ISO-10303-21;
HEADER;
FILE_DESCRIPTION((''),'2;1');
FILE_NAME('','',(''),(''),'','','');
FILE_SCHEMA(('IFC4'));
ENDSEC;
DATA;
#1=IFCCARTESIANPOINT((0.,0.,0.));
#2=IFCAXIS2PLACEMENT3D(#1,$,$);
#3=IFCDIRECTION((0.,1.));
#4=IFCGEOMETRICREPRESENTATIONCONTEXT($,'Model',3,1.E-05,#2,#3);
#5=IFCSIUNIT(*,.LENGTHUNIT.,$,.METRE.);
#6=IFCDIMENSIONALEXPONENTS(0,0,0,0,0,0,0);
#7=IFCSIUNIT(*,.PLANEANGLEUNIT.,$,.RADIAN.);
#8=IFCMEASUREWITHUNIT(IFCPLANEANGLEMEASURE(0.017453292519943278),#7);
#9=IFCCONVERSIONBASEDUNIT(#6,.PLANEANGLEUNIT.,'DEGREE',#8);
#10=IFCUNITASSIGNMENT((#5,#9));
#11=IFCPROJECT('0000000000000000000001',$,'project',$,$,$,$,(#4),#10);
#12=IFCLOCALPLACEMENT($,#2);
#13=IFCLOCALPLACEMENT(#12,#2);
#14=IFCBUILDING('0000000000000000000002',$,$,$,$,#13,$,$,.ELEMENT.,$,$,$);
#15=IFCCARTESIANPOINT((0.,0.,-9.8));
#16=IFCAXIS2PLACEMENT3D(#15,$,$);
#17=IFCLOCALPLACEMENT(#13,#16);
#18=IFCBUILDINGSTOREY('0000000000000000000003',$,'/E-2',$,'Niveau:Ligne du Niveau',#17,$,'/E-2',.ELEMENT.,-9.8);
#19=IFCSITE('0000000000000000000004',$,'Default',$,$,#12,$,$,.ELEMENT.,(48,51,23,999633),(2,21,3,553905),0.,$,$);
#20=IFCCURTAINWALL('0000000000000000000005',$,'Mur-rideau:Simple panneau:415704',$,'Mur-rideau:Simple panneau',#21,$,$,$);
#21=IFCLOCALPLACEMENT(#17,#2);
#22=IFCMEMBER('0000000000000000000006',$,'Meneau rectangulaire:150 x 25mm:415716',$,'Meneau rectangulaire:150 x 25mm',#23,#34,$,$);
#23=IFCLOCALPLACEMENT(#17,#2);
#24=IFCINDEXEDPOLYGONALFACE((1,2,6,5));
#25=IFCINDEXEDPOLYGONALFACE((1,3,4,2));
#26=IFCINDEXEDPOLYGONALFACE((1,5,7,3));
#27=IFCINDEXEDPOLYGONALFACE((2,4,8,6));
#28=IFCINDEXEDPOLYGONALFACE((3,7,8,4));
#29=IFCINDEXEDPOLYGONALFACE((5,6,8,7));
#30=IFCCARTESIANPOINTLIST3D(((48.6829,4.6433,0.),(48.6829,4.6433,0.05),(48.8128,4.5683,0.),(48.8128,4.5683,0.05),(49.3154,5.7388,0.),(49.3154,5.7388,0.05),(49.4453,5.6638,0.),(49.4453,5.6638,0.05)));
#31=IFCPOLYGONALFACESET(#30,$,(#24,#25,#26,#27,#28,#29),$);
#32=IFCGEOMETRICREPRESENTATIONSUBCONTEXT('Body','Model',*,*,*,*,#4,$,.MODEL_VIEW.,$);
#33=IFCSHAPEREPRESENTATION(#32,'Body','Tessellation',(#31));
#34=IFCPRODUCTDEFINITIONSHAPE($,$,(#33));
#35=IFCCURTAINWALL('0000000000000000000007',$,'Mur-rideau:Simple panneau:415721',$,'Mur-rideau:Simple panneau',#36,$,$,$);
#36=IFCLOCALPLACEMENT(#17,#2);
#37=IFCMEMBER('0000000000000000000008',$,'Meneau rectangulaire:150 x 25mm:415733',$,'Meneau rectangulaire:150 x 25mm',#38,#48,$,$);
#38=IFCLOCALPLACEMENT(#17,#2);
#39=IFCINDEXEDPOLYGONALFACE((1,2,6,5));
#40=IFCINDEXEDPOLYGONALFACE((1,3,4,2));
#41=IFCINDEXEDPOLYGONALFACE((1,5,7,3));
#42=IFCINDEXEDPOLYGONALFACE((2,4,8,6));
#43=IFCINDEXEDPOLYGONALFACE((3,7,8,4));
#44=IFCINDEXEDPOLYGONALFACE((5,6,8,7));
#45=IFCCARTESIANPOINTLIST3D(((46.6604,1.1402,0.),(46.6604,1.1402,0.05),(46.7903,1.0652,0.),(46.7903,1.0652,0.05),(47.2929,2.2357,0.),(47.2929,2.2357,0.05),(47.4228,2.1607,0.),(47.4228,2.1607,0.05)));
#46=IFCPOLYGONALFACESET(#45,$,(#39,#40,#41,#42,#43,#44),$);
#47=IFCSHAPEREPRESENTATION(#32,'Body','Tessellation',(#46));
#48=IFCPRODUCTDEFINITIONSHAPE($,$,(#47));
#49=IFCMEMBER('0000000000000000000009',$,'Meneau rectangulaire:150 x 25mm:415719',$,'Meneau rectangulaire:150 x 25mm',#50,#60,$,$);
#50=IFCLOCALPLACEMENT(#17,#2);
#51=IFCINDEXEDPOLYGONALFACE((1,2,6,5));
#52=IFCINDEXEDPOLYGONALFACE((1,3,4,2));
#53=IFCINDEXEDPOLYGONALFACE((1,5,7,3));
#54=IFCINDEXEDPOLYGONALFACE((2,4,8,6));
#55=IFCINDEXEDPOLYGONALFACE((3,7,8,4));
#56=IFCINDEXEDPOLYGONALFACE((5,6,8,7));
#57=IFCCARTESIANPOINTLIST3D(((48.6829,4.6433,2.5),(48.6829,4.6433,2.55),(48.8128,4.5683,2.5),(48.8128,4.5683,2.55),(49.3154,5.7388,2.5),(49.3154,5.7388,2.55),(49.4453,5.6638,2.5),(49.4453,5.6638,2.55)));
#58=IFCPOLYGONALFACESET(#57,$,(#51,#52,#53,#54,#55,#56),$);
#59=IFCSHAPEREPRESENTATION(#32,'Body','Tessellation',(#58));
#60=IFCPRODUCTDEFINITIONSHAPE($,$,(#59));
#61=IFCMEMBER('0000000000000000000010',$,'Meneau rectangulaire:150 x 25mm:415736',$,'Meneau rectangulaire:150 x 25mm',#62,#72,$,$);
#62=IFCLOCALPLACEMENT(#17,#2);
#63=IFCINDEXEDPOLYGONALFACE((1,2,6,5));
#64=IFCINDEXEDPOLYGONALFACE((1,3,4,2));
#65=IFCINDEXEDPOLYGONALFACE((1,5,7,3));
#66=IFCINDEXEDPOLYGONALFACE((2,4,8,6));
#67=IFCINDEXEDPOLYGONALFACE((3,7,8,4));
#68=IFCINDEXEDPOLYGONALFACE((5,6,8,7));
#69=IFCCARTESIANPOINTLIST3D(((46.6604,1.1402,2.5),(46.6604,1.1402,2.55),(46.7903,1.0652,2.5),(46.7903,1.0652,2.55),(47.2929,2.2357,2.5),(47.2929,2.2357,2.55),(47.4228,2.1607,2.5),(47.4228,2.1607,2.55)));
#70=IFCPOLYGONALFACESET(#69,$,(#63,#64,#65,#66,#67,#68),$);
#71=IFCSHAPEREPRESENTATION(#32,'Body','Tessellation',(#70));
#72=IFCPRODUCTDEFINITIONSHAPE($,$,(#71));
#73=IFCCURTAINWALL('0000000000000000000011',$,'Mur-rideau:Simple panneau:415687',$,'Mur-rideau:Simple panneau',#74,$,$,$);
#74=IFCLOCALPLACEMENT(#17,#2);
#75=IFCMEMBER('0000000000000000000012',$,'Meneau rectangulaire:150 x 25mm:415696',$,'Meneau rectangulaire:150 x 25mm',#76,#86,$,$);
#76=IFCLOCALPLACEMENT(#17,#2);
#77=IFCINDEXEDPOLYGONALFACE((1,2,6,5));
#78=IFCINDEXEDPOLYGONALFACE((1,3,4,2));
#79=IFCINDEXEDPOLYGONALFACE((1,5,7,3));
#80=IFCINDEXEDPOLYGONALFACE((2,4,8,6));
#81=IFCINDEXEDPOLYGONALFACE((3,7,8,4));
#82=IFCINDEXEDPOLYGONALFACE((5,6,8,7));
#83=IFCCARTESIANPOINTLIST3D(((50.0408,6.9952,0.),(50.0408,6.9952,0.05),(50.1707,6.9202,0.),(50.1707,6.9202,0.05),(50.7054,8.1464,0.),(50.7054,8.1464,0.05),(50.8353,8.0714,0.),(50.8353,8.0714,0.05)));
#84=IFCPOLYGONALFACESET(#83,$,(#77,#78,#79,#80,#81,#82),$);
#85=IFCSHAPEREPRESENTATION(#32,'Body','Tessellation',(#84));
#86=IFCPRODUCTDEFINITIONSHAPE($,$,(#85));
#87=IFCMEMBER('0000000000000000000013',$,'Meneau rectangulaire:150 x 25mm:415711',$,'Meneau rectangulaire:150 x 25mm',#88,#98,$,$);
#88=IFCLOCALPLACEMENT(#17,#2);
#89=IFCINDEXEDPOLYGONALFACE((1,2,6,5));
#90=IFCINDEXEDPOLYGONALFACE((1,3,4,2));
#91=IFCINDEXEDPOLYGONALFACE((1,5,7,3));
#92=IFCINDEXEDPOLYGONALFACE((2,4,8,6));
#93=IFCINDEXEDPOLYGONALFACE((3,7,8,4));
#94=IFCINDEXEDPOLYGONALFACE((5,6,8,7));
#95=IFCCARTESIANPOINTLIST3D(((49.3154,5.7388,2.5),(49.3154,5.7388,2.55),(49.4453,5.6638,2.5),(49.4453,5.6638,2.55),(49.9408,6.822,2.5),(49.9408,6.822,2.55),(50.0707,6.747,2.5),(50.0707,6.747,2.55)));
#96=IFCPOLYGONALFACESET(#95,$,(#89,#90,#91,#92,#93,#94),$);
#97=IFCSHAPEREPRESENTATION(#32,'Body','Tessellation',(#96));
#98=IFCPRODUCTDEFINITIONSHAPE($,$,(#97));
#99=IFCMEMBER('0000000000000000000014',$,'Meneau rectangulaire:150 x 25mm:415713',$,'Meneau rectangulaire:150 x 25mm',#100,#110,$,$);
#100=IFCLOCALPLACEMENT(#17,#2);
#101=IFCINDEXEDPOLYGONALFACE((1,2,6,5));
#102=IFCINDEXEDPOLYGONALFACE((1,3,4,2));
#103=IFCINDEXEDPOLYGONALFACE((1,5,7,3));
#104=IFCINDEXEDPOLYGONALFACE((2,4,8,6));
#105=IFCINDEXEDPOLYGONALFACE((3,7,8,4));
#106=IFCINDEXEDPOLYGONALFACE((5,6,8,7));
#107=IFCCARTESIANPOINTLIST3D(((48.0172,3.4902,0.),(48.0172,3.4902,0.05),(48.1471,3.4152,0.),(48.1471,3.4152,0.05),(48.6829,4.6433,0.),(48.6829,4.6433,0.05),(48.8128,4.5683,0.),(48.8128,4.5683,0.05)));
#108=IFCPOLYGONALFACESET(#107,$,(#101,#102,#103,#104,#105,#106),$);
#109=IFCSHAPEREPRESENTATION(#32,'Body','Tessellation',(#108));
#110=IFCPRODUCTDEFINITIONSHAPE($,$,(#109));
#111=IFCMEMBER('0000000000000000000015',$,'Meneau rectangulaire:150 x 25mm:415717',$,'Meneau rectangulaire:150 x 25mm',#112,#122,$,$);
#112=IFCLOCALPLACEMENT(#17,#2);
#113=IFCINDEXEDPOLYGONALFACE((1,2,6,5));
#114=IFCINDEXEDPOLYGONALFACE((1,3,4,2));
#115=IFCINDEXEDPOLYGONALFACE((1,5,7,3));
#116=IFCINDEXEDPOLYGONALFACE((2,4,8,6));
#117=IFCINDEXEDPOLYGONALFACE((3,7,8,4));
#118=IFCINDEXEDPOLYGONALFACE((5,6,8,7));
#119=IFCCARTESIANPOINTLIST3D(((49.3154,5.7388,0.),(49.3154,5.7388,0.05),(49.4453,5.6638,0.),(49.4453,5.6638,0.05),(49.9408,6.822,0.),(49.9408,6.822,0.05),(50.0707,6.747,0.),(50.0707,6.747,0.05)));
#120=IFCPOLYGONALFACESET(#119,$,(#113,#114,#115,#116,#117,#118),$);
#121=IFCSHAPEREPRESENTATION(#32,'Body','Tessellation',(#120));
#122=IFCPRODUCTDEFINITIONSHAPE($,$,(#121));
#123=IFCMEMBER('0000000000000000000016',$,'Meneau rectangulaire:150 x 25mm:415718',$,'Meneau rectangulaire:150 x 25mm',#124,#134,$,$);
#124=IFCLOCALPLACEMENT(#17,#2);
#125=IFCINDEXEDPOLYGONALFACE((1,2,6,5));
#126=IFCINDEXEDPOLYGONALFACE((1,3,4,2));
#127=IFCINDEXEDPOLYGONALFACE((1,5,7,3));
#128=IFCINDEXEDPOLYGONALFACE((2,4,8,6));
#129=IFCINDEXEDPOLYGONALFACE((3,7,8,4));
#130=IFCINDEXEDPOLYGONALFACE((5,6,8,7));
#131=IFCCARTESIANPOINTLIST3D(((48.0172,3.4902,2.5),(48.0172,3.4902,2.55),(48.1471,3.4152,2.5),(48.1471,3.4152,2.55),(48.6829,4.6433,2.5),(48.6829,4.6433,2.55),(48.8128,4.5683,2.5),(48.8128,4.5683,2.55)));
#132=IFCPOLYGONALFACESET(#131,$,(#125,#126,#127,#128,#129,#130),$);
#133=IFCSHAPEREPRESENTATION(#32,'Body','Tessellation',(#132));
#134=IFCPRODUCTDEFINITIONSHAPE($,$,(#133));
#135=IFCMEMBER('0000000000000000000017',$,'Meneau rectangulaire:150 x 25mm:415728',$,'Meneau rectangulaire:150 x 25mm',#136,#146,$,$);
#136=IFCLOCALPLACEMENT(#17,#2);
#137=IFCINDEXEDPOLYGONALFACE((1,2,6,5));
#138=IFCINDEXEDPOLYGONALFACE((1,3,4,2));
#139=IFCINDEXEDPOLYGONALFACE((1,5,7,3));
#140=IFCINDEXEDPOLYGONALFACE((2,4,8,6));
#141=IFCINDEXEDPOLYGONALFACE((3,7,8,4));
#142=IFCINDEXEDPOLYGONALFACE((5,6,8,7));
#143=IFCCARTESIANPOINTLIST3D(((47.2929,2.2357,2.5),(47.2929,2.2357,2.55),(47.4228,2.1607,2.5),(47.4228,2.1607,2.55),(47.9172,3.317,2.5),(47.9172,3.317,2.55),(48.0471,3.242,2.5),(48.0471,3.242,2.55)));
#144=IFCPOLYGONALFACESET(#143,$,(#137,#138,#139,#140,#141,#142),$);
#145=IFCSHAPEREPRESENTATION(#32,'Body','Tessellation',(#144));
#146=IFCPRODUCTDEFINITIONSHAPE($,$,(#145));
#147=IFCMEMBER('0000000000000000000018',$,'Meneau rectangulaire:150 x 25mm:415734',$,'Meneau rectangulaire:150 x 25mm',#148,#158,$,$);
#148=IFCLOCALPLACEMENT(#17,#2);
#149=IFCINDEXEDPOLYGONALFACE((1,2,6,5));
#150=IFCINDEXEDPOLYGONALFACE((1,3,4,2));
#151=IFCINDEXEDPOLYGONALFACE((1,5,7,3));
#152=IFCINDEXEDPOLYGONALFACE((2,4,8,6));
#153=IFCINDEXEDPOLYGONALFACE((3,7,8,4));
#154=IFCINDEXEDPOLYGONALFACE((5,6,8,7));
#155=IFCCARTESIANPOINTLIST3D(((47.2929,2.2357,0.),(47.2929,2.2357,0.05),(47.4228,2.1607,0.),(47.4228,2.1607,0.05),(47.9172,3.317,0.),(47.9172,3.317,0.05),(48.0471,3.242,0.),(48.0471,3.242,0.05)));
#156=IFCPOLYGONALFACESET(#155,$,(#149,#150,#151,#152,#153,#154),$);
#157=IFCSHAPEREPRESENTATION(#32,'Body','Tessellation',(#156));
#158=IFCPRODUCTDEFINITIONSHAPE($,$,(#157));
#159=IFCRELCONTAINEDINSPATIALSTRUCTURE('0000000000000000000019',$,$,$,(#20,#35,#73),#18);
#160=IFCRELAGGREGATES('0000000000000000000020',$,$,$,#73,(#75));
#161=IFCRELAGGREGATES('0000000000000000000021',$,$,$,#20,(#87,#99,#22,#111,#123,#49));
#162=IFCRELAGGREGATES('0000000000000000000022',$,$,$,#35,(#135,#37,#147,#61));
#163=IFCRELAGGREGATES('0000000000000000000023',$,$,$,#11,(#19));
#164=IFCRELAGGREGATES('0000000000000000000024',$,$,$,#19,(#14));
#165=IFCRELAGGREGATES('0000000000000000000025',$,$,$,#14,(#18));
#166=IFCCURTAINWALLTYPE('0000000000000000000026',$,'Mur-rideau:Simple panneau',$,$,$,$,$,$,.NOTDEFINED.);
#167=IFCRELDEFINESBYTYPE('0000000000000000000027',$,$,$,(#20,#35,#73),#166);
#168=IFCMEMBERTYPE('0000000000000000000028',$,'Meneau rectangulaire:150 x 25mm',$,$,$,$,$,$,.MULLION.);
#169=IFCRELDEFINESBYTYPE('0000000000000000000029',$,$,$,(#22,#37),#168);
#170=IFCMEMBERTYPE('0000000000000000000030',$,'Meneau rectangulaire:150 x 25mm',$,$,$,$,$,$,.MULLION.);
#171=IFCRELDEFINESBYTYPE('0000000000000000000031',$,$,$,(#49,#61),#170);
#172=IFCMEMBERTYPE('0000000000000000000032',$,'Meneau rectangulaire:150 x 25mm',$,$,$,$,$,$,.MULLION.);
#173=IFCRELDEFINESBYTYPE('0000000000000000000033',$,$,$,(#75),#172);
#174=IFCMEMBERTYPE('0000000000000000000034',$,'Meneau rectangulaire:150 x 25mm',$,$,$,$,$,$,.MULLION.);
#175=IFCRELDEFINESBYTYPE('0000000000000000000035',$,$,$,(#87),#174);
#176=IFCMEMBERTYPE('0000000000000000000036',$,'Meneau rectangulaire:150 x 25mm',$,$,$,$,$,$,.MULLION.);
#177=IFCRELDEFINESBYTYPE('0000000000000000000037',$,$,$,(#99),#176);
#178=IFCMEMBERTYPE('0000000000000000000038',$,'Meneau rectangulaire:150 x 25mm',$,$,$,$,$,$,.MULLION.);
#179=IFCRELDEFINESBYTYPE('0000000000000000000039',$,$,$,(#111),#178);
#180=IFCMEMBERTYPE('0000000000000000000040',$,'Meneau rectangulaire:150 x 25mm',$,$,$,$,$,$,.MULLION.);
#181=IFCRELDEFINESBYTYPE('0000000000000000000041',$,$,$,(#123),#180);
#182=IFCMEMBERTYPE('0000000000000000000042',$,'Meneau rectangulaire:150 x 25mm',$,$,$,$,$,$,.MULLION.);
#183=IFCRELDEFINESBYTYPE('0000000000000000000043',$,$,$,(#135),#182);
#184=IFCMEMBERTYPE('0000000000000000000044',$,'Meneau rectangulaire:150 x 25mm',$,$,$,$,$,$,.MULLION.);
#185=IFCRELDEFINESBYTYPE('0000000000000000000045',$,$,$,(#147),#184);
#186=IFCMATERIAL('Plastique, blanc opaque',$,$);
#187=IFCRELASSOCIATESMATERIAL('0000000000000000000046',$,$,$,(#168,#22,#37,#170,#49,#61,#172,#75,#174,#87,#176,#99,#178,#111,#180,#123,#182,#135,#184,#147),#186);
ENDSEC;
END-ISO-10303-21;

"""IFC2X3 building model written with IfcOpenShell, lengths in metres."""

from ifc_helpers import new_model, entity, si_unit, converted_unit, direction, frame, frame_2d, origin, origin_2d_with_axis, place, context, subcontext, project, spatial, rectangle, extrude, source, transform, mapped, material, type_object, type_shapes, element, aggregate, save


model = new_model("IFC2X3")

# Units and contexts
model_context = context("Model", 3, precision=1e-05, world=origin(), true_north=direction((0.0, 1.0)))
body_context = subcontext(model_context, "Body", "Model", "MODEL_VIEW")
ifc_project = project(units=[si_unit("LENGTHUNIT", "METRE"), converted_unit("PLANEANGLEUNIT", "DEGREE", entity("IfcPlaneAngleMeasure", 0.017453292519943278), si_unit("PLANEANGLEUNIT", "RADIAN"), dimensions=[0, 0, 0, 0, 0, 0, 0])], contexts=[model_context])

# Site, building, storey
site_placement = place(None, origin())
site = spatial("IfcSite", under=ifc_project, at=site_placement, Name="Default", CompositionType="ELEMENT", RefLatitude=(48, 51, 23, 999633), RefLongitude=(2, 21, 3, 553905), RefElevation=0.0)
building_placement = place(site_placement, origin())
building = spatial("IfcBuilding", under=site, at=building_placement, CompositionType="ELEMENT")
storey_placement = place(building_placement, frame((0.0, 0.0, -9.8)))
storey = spatial("IfcBuildingStorey", under=building, at=storey_placement, Name="/E-2", ObjectType="Niveau:Ligne du Niveau", LongName="/E-2", CompositionType="ELEMENT", Elevation=-9.8)

# Curtain walls, members
curtain_wall_type = type_object("IfcCurtainWallType", Name="Mur-rideau:Simple panneau", PredefinedType="NOTDEFINED")
curtain_wall_1_placement = place(storey_placement, frame((0.0, 0.0, 9.8)))
curtain_wall_1 = element("IfcCurtainWall", 1, at=curtain_wall_1_placement, inside=storey, type_object=curtain_wall_type, Name="Mur-rideau:Simple panneau:415704", ObjectType="Mur-rideau:Simple panneau")
ifc_material_1 = material(Name="Plastique, blanc opaque")
member_type_1 = type_object("IfcMemberType", Name="Meneau rectangulaire:150 x 25mm", PredefinedType="MULLION", material=ifc_material_1)
shared_shape_1 = source(origin(), body_context, "Body", "SweptSolid", [
    extrude(rectangle(XDim=0.05, YDim=0.15, at=origin_2d_with_axis()), frame((-0.025, 0.0, -1.265), z_axis=(0.0, 0.0, 1.0), x_axis=(-1.0, 0.0, 0.0)), (0.0, 0.0, 1.0), 1.265),
])
type_shapes(member_type_1, [shared_shape_1])
member_1_placement = place(curtain_wall_1_placement, frame((48.7479, 4.6058, -9.8), z_axis=(-0.5, -0.866025, 0.0), x_axis=(0.0, 0.0, -1.0)))
member_1 = element("IfcMember", 2, at=member_1_placement, type_object=member_type_1, material=ifc_material_1, Name="Meneau rectangulaire:150 x 25mm:415716", ObjectType="Meneau rectangulaire:150 x 25mm", context=body_context, shape_type="MappedRepresentation", body=[
    mapped(shared_shape_1, transform((0.0, 0.0, 0.0), scale=1.0)),
])
curtain_wall_2_placement = place(storey_placement, frame((0.0, 0.0, 9.8)))
curtain_wall_2 = element("IfcCurtainWall", 3, at=curtain_wall_2_placement, inside=storey, type_object=curtain_wall_type, Name="Mur-rideau:Simple panneau:415721", ObjectType="Mur-rideau:Simple panneau")
member_2_placement = place(curtain_wall_2_placement, frame((46.7254, 1.1027, -9.8), z_axis=(-0.5, -0.866025, 0.0), x_axis=(0.0, 0.0, -1.0)))
member_2 = element("IfcMember", 4, at=member_2_placement, type_object=member_type_1, material=ifc_material_1, Name="Meneau rectangulaire:150 x 25mm:415733", ObjectType="Meneau rectangulaire:150 x 25mm", context=body_context, shape_type="MappedRepresentation", body=[
    mapped(shared_shape_1, transform((0.0, 0.0, 0.0), scale=1.0)),
])

# Members
member_type_2 = type_object("IfcMemberType", Name="Meneau rectangulaire:150 x 25mm", PredefinedType="MULLION", material=ifc_material_1)
shared_shape_2 = source(origin(), body_context, "Body", "SweptSolid", [
    extrude(rectangle(XDim=0.05, YDim=0.15, at=origin_2d_with_axis()), frame((-0.025, 0.0, -1.265), z_axis=(0.0, 0.0, 1.0), x_axis=(-1.0, 0.0, 0.0)), (0.0, 0.0, 1.0), 1.265),
])
type_shapes(member_type_2, [shared_shape_2])
member_3_placement = place(curtain_wall_1_placement, frame((49.3804, 5.7013, -7.25), z_axis=(0.5, 0.866025, 0.0), x_axis=(0.0, 0.0, 1.0)))
member_3 = element("IfcMember", 5, at=member_3_placement, type_object=member_type_2, material=ifc_material_1, Name="Meneau rectangulaire:150 x 25mm:415719", ObjectType="Meneau rectangulaire:150 x 25mm", context=body_context, shape_type="MappedRepresentation", body=[
    mapped(shared_shape_2, transform((0.0, 0.0, 0.0), scale=1.0)),
])
member_4_placement = place(curtain_wall_2_placement, frame((47.3579, 2.1982, -7.25), z_axis=(0.5, 0.866025, 0.0), x_axis=(0.0, 0.0, 1.0)))
member_4 = element("IfcMember", 6, at=member_4_placement, type_object=member_type_2, material=ifc_material_1, Name="Meneau rectangulaire:150 x 25mm:415736", ObjectType="Meneau rectangulaire:150 x 25mm", context=body_context, shape_type="MappedRepresentation", body=[
    mapped(shared_shape_2, transform((0.0, 0.0, 0.0), scale=1.0)),
])

# Curtain wall, member
curtain_wall_3_placement = place(storey_placement, frame((0.0, 0.0, 9.8)))
curtain_wall_3 = element("IfcCurtainWall", 7, at=curtain_wall_3_placement, inside=storey, type_object=curtain_wall_type, Name="Mur-rideau:Simple panneau:415687", ObjectType="Mur-rideau:Simple panneau")
member_type_3 = type_object("IfcMemberType", Name="Meneau rectangulaire:150 x 25mm", PredefinedType="MULLION", material=ifc_material_1)
shared_shape_3 = source(origin(), body_context, "Body", "SweptSolid", [
    extrude(rectangle(XDim=0.05, YDim=0.15, at=origin_2d_with_axis()), frame((-0.025, 0.0, -1.3292), z_axis=(0.0, 0.0, 1.0), x_axis=(-1.0, 0.0, 0.0)), (0.0, 0.0, 1.0), 1.3292),
])
type_shapes(member_type_3, [shared_shape_3])
member_5_placement = place(curtain_wall_3_placement, frame((50.1058, 6.9577, -9.8), z_axis=(-0.5, -0.866025, 0.0), x_axis=(0.0, 0.0, -1.0)))
member_5 = element("IfcMember", 8, at=member_5_placement, type_object=member_type_3, material=ifc_material_1, Name="Meneau rectangulaire:150 x 25mm:415696", ObjectType="Meneau rectangulaire:150 x 25mm", context=body_context, shape_type="MappedRepresentation", body=[
    mapped(shared_shape_3, transform((0.0, 0.0, 0.0), scale=1.0)),
])

# Members
member_type_4 = type_object("IfcMemberType", Name="Meneau rectangulaire:150 x 25mm", PredefinedType="MULLION", material=ifc_material_1)
shared_shape_4 = source(origin(), body_context, "Body", "SweptSolid", [
    extrude(rectangle(XDim=0.05, YDim=0.15, at=origin_2d_with_axis()), frame((-0.025, 0.0, -1.2508), z_axis=(0.0, 0.0, 1.0), x_axis=(-1.0, 0.0, 0.0)), (0.0, 0.0, 1.0), 1.2508),
])
type_shapes(member_type_4, [shared_shape_4])
member_6_placement = place(curtain_wall_1_placement, frame((50.0058, 6.7845, -7.25), z_axis=(0.5, 0.866025, 0.0), x_axis=(0.0, 0.0, 1.0)))
member_6 = element("IfcMember", 9, at=member_6_placement, type_object=member_type_4, material=ifc_material_1, Name="Meneau rectangulaire:150 x 25mm:415711", ObjectType="Meneau rectangulaire:150 x 25mm", context=body_context, shape_type="MappedRepresentation", body=[
    mapped(shared_shape_4, transform((0.0, 0.0, 0.0), scale=1.0)),
])
member_type_5 = type_object("IfcMemberType", Name="Meneau rectangulaire:150 x 25mm", PredefinedType="MULLION", material=ifc_material_1)
shared_shape_5 = source(origin(), body_context, "Body", "SweptSolid", [
    extrude(rectangle(XDim=0.05, YDim=0.15, at=origin_2d_with_axis()), frame((-0.025, 0.0, -1.3314), z_axis=(0.0, 0.0, 1.0), x_axis=(-1.0, 0.0, 0.0)), (0.0, 0.0, 1.0), 1.3314),
])
type_shapes(member_type_5, [shared_shape_5])
member_7_placement = place(curtain_wall_1_placement, frame((48.0822, 3.4527, -9.8), z_axis=(-0.5, -0.866025, 0.0), x_axis=(0.0, 0.0, -1.0)))
member_7 = element("IfcMember", 10, at=member_7_placement, type_object=member_type_5, material=ifc_material_1, Name="Meneau rectangulaire:150 x 25mm:415713", ObjectType="Meneau rectangulaire:150 x 25mm", context=body_context, shape_type="MappedRepresentation", body=[
    mapped(shared_shape_5, transform((0.0, 0.0, 0.0), scale=1.0)),
])
member_type_6 = type_object("IfcMemberType", Name="Meneau rectangulaire:150 x 25mm", PredefinedType="MULLION", material=ifc_material_1)
shared_shape_6 = source(origin(), body_context, "Body", "SweptSolid", [
    extrude(rectangle(XDim=0.05, YDim=0.15, at=origin_2d_with_axis()), frame((-0.025, 0.0, -1.2508), z_axis=(0.0, 0.0, 1.0), x_axis=(-1.0, 0.0, 0.0)), (0.0, 0.0, 1.0), 1.2508),
])
type_shapes(member_type_6, [shared_shape_6])
member_8_placement = place(curtain_wall_1_placement, frame((49.3804, 5.7013, -9.8), z_axis=(-0.5, -0.866025, 0.0), x_axis=(0.0, 0.0, -1.0)))
member_8 = element("IfcMember", 11, at=member_8_placement, type_object=member_type_6, material=ifc_material_1, Name="Meneau rectangulaire:150 x 25mm:415717", ObjectType="Meneau rectangulaire:150 x 25mm", context=body_context, shape_type="MappedRepresentation", body=[
    mapped(shared_shape_6, transform((0.0, 0.0, 0.0), scale=1.0)),
])
member_type_7 = type_object("IfcMemberType", Name="Meneau rectangulaire:150 x 25mm", PredefinedType="MULLION", material=ifc_material_1)
shared_shape_7 = source(origin(), body_context, "Body", "SweptSolid", [
    extrude(rectangle(XDim=0.05, YDim=0.15, at=frame_2d((0.0, 0.0), x_axis=(1.0, 0.0))), frame((-0.025, 0.0, -1.3314), z_axis=(0.0, 0.0, 1.0), x_axis=(-1.0, 0.0, 0.0)), (0.0, 0.0, 1.0), 1.3314),
])
type_shapes(member_type_7, [shared_shape_7])
member_9_placement = place(curtain_wall_1_placement, frame((48.7479, 4.6058, -7.25), z_axis=(0.5, 0.866025, 0.0), x_axis=(0.0, 0.0, 1.0)))
member_9 = element("IfcMember", 12, at=member_9_placement, type_object=member_type_7, material=ifc_material_1, Name="Meneau rectangulaire:150 x 25mm:415718", ObjectType="Meneau rectangulaire:150 x 25mm", context=body_context, shape_type="MappedRepresentation", body=[
    mapped(shared_shape_7, transform((0.0, 0.0, 0.0), scale=1.0)),
])
member_type_8 = type_object("IfcMemberType", Name="Meneau rectangulaire:150 x 25mm", PredefinedType="MULLION", material=ifc_material_1)
shared_shape_8 = source(origin(), body_context, "Body", "SweptSolid", [
    extrude(rectangle(XDim=0.05, YDim=0.15, at=origin_2d_with_axis()), frame((-0.025, 0.0, -1.2486), z_axis=(0.0, 0.0, 1.0), x_axis=(-1.0, 0.0, 0.0)), (0.0, 0.0, 1.0), 1.2486),
])
type_shapes(member_type_8, [shared_shape_8])
member_10_placement = place(curtain_wall_2_placement, frame((47.9822, 3.2795, -7.25), z_axis=(0.5, 0.866025, 0.0), x_axis=(0.0, 0.0, 1.0)))
member_10 = element("IfcMember", 13, at=member_10_placement, type_object=member_type_8, material=ifc_material_1, Name="Meneau rectangulaire:150 x 25mm:415728", ObjectType="Meneau rectangulaire:150 x 25mm", context=body_context, shape_type="MappedRepresentation", body=[
    mapped(shared_shape_8, transform((0.0, 0.0, 0.0), scale=1.0)),
])
member_type_9 = type_object("IfcMemberType", Name="Meneau rectangulaire:150 x 25mm", PredefinedType="MULLION", material=ifc_material_1)
shared_shape_9 = source(origin(), body_context, "Body", "SweptSolid", [
    extrude(rectangle(XDim=0.05, YDim=0.15, at=origin_2d_with_axis()), frame((-0.025, 0.0, -1.2486), z_axis=(0.0, 0.0, 1.0), x_axis=(-1.0, 0.0, 0.0)), (0.0, 0.0, 1.0), 1.2486),
])
type_shapes(member_type_9, [shared_shape_9])
member_11_placement = place(curtain_wall_2_placement, frame((47.3579, 2.1982, -9.8), z_axis=(-0.5, -0.866025, 0.0), x_axis=(0.0, 0.0, -1.0)))
member_11 = element("IfcMember", 14, at=member_11_placement, type_object=member_type_9, material=ifc_material_1, Name="Meneau rectangulaire:150 x 25mm:415734", ObjectType="Meneau rectangulaire:150 x 25mm", context=body_context, shape_type="MappedRepresentation", body=[
    mapped(shared_shape_9, transform((0.0, 0.0, 0.0), scale=1.0)),
])

aggregate(curtain_wall_3, [member_5])
aggregate(curtain_wall_1, [member_6, member_7, member_1, member_8, member_9, member_3])
aggregate(curtain_wall_2, [member_10, member_2, member_11, member_4])

save(model, "model.ifc")
